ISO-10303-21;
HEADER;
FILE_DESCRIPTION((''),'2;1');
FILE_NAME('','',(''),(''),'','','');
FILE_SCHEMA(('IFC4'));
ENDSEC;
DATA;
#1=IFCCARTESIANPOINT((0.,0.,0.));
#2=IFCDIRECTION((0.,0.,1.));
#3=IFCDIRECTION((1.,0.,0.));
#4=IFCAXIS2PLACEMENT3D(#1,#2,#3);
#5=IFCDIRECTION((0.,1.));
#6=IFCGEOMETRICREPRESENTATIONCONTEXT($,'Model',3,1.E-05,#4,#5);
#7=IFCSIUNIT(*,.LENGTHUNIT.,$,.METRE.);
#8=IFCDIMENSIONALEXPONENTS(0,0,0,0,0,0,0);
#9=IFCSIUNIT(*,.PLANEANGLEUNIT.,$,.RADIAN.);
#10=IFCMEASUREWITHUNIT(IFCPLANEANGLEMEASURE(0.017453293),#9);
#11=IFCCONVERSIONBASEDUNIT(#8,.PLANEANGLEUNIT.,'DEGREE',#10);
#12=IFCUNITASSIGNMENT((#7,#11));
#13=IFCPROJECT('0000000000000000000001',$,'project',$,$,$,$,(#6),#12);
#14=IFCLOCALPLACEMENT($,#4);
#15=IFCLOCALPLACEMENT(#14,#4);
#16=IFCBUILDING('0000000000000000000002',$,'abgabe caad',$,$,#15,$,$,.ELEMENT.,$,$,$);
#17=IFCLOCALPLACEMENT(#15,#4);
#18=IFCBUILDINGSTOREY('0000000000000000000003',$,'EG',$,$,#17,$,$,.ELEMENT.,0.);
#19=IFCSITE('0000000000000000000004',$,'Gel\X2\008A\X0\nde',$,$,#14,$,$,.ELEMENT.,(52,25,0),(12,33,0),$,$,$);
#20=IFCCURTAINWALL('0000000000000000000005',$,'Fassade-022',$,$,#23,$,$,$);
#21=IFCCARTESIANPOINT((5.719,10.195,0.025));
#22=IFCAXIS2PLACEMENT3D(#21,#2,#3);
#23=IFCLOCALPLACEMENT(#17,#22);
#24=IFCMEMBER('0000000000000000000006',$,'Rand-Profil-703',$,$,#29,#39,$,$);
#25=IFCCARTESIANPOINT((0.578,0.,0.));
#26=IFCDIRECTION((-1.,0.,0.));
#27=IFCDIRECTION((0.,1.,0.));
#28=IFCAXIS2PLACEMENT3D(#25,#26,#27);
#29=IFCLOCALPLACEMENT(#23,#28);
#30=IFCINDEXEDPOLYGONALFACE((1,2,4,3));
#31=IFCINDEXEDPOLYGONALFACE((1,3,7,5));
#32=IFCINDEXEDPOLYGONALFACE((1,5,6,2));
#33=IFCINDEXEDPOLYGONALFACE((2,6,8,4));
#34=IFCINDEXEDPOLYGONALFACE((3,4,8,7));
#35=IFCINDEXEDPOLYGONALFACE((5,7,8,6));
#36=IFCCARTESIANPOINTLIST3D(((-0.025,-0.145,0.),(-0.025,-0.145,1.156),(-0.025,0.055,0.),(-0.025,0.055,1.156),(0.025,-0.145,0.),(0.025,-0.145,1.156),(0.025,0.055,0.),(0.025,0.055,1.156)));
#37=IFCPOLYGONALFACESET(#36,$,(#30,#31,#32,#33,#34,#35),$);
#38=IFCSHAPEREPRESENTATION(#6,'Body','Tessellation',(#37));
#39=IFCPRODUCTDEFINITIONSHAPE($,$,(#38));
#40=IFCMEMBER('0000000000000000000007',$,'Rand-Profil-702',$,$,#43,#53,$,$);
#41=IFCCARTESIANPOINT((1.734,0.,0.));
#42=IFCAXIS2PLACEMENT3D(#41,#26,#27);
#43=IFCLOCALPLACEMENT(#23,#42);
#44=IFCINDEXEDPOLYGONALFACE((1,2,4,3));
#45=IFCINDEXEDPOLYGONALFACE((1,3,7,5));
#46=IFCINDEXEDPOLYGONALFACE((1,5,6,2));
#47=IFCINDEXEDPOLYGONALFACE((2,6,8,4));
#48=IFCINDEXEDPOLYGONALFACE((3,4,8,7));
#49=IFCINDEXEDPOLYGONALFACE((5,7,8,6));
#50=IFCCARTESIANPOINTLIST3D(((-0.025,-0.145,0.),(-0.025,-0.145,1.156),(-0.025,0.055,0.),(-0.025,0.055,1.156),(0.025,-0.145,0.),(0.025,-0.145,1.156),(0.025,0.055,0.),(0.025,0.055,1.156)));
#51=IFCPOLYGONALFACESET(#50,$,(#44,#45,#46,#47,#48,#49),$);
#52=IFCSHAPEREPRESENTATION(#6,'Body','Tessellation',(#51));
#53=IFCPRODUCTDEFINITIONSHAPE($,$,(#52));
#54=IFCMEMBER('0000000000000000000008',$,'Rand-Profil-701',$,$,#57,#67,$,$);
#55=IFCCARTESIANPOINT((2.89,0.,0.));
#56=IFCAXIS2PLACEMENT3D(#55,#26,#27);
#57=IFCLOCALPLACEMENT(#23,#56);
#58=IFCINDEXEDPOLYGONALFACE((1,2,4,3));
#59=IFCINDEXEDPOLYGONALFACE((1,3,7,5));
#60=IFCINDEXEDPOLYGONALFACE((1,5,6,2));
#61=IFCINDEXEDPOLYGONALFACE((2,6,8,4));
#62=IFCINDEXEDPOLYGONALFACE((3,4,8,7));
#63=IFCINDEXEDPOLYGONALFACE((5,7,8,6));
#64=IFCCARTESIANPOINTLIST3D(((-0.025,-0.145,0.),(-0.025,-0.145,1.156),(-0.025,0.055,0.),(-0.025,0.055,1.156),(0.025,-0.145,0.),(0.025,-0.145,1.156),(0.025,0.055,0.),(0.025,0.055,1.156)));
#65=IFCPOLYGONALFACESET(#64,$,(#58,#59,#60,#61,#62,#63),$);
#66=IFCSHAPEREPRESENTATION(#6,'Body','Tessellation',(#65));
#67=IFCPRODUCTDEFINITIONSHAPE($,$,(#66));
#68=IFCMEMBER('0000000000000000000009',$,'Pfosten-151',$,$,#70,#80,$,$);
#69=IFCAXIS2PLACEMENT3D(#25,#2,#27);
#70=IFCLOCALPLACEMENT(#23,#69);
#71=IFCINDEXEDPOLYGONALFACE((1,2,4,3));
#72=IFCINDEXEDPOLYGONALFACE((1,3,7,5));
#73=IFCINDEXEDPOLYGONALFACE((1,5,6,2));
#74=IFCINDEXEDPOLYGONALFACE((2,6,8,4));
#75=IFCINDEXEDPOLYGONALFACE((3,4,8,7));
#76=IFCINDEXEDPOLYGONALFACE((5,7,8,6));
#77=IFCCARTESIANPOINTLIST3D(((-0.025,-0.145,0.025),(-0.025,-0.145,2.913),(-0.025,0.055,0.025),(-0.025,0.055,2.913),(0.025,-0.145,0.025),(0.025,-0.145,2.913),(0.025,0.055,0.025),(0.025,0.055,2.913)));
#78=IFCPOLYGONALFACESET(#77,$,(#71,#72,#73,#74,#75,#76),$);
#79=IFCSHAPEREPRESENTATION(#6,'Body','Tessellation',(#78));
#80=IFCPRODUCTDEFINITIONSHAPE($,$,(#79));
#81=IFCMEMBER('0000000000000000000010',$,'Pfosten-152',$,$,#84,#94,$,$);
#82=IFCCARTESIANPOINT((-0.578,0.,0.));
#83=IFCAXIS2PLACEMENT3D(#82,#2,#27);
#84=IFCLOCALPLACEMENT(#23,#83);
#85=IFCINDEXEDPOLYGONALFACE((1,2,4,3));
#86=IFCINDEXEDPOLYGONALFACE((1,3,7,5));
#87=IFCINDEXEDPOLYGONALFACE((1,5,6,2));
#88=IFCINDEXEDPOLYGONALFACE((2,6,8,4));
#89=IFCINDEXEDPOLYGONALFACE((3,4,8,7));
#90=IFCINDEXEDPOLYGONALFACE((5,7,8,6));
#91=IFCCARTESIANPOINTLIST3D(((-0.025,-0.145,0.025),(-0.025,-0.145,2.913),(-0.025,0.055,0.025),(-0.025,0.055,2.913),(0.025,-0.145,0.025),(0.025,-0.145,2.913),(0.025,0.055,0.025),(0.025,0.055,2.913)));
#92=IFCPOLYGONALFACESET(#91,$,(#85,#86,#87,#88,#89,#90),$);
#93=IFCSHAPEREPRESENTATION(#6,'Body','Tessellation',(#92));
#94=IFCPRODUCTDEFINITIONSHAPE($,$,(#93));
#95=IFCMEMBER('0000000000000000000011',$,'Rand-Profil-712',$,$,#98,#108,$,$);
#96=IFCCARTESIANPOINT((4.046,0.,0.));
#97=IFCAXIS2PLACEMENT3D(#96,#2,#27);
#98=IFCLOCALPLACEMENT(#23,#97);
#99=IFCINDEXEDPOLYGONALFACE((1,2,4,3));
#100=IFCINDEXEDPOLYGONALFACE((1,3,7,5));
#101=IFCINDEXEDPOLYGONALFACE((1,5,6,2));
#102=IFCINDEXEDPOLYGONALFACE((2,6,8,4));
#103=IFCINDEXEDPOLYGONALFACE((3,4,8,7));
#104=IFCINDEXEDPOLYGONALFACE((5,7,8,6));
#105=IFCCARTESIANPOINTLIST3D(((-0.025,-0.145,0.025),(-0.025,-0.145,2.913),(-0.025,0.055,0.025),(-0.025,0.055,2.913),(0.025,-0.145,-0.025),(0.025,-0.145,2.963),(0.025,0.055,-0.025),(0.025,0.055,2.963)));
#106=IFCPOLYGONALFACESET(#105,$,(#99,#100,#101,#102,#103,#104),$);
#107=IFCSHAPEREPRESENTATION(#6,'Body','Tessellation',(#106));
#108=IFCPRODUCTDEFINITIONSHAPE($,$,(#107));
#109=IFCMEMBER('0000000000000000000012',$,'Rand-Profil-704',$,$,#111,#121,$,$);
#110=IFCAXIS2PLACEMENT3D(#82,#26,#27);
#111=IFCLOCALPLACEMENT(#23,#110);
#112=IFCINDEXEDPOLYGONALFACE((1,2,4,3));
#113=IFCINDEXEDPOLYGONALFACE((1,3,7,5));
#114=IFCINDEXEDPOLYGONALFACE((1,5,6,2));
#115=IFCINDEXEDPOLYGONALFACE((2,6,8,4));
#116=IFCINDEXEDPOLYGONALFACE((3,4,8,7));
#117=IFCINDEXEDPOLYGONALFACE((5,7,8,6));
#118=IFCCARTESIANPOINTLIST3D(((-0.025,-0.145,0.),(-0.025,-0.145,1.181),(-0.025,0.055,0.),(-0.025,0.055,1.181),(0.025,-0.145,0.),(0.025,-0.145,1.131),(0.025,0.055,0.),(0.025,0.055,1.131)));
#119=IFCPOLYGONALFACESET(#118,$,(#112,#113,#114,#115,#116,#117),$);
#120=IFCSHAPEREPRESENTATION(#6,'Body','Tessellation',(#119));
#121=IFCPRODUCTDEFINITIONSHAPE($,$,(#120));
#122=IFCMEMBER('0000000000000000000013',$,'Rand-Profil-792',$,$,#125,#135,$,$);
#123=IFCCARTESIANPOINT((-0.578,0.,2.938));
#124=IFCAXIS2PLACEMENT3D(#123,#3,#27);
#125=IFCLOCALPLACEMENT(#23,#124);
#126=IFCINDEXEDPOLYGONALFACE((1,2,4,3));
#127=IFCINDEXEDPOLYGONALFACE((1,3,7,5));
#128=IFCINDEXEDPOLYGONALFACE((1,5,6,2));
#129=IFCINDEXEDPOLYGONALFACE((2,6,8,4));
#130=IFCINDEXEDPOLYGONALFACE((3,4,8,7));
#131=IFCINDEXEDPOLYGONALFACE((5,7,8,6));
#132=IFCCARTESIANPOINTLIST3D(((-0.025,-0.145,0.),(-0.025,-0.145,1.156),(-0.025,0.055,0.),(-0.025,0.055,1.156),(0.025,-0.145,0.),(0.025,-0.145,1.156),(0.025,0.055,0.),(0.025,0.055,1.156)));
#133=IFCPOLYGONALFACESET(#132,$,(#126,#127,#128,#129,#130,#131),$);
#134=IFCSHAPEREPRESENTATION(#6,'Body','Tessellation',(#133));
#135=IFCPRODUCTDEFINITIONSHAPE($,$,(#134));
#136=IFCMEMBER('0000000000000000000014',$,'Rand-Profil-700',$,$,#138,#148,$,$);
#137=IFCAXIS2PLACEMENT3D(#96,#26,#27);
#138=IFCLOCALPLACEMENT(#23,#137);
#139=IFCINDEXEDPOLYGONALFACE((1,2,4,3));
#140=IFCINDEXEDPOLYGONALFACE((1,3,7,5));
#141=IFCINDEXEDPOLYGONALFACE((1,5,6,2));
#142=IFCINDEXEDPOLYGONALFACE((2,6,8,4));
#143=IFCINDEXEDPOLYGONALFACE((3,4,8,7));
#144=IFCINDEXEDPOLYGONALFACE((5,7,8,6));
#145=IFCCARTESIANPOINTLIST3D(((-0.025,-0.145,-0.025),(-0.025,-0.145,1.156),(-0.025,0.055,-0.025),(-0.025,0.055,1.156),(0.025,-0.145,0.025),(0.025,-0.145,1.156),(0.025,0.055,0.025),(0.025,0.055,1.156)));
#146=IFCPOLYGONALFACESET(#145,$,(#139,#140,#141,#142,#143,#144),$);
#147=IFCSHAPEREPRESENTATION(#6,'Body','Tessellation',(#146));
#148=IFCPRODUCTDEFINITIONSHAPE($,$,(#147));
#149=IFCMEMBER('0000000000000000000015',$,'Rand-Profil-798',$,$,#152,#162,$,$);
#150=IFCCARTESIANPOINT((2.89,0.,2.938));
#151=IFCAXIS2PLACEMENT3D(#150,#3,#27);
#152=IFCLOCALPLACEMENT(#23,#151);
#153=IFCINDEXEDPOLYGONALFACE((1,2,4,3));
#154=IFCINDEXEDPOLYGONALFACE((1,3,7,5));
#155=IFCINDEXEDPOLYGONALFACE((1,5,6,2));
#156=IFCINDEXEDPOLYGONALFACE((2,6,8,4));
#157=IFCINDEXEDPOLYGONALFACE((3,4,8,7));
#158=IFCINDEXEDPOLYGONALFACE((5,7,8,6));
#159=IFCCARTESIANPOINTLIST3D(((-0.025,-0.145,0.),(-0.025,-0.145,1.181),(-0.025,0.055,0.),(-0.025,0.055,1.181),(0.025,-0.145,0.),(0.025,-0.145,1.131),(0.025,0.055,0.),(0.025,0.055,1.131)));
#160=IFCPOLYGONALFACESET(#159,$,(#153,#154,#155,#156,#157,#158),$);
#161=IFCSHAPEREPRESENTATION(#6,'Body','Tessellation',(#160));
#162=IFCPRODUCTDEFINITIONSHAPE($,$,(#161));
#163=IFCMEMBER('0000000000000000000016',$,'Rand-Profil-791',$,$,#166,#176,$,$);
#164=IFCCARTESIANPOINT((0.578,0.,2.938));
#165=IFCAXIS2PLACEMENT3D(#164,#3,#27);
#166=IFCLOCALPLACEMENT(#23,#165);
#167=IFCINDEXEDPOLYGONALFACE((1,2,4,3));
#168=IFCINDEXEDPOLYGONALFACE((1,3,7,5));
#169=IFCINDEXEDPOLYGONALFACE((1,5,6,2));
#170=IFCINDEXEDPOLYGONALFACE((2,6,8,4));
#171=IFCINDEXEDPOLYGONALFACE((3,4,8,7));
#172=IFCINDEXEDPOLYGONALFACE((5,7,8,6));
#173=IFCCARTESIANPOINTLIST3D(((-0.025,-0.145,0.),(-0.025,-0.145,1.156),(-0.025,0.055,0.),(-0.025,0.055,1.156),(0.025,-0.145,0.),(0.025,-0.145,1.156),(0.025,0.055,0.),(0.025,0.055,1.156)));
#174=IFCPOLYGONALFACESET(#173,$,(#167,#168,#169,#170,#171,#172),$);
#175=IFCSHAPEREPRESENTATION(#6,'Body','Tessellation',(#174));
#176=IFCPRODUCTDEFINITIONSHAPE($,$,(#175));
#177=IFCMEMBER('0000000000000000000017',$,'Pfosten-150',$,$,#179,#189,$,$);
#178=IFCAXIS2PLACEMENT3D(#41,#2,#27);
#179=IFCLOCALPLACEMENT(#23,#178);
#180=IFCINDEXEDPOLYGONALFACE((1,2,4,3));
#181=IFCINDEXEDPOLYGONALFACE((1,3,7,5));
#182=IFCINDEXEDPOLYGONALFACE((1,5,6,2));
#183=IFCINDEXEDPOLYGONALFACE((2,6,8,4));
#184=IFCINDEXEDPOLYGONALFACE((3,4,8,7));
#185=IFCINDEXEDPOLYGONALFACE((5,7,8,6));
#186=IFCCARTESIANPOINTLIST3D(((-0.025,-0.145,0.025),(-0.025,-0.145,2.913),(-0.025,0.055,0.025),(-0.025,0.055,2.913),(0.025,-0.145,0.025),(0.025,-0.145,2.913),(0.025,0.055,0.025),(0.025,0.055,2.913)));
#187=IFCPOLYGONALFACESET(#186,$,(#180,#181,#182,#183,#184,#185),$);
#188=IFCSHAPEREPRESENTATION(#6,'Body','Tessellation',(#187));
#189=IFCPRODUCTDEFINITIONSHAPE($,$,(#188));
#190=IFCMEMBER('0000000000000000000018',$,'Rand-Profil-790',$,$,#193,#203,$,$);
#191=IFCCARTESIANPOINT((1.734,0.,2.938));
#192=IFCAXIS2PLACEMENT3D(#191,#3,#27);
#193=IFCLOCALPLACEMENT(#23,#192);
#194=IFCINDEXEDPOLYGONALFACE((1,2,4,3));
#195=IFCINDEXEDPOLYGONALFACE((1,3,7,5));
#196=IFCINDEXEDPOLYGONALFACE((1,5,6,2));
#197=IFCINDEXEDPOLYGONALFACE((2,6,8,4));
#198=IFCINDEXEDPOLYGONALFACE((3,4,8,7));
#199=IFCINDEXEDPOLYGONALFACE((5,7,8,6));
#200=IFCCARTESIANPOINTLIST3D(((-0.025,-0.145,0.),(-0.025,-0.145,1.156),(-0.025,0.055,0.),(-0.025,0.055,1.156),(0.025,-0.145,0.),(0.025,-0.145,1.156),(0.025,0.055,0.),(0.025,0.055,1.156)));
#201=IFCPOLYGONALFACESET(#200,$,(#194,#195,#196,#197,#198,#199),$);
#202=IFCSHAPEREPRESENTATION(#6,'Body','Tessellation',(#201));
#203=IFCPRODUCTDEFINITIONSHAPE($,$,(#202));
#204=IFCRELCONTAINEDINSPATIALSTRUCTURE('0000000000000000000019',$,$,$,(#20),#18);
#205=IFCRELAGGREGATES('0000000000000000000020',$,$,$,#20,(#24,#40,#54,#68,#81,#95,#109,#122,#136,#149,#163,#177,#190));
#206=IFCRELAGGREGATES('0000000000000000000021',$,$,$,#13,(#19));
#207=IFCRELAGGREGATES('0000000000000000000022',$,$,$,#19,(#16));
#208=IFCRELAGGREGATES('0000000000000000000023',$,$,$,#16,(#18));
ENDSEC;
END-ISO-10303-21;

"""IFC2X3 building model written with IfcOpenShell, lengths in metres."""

from ifc_helpers import new_model, entity, si_unit, converted_unit, direction, frame, origin_with_axes, place, context, project, spatial, polyline, outline, extrude, clip, halfspace, element, aggregate, save


model = new_model("IFC2X3")

# Units and contexts
model_context = context("Model", 3, precision=1e-05, world=origin_with_axes(), true_north=direction((0.0, 1.0)))
ifc_project = project(units=[si_unit("LENGTHUNIT", "METRE"), converted_unit("PLANEANGLEUNIT", "DEGREE", entity("IfcPlaneAngleMeasure", 0.017453293), si_unit("PLANEANGLEUNIT", "RADIAN"), dimensions=[0, 0, 0, 0, 0, 0, 0])], contexts=[model_context])

# Site, building, storey
site_placement = place(None, origin_with_axes())
site = spatial("IfcSite", under=ifc_project, at=site_placement, Name="Gel\u008ande", CompositionType="ELEMENT", RefLatitude=(52, 25, 0), RefLongitude=(12, 33, 0))
building_placement = place(site_placement, origin_with_axes())
building = spatial("IfcBuilding", under=site, at=building_placement, Name="abgabe caad", CompositionType="ELEMENT")
storey_placement = place(building_placement, origin_with_axes())
storey = spatial("IfcBuildingStorey", under=building, at=storey_placement, Name="EG", CompositionType="ELEMENT", Elevation=0.0)

# Curtain wall, members
curtain_wall_placement = place(storey_placement, frame((5.719, 10.195, 0.025), z_axis=(0.0, 0.0, 1.0), x_axis=(1.0, 0.0, 0.0)))
curtain_wall = element("IfcCurtainWall", 1, at=curtain_wall_placement, inside=storey, Name="Fassade-022")
member_1_placement = place(curtain_wall_placement, frame((0.578, 0.0, 0.0), z_axis=(-1.0, 0.0, 0.0), x_axis=(0.0, 1.0, 0.0)))
member_1 = element("IfcMember", 2, at=member_1_placement, Name="Rand-Profil-703", context=model_context, shape_type="SweptSolid", body=[
    extrude(outline(polyline([(0.025, -0.145), (0.025, 0.055), (-0.025, 0.055), (-0.025, -0.145), (0.025, -0.145)])), origin_with_axes(), (0.0, 0.0, 1.0), 1.156),
])
member_2_placement = place(curtain_wall_placement, frame((1.734, 0.0, 0.0), z_axis=(-1.0, 0.0, 0.0), x_axis=(0.0, 1.0, 0.0)))
member_2 = element("IfcMember", 3, at=member_2_placement, Name="Rand-Profil-702", context=model_context, shape_type="SweptSolid", body=[
    extrude(outline(polyline([(0.025, -0.145), (0.025, 0.055), (-0.025, 0.055), (-0.025, -0.145), (0.025, -0.145)])), origin_with_axes(), (0.0, 0.0, 1.0), 1.156),
])
member_3_placement = place(curtain_wall_placement, frame((2.89, 0.0, 0.0), z_axis=(-1.0, 0.0, 0.0), x_axis=(0.0, 1.0, 0.0)))
member_3 = element("IfcMember", 4, at=member_3_placement, Name="Rand-Profil-701", context=model_context, shape_type="SweptSolid", body=[
    extrude(outline(polyline([(0.025, -0.145), (0.025, 0.055), (-0.025, 0.055), (-0.025, -0.145), (0.025, -0.145)])), origin_with_axes(), (0.0, 0.0, 1.0), 1.156),
])
member_4_placement = place(curtain_wall_placement, frame((0.578, 0.0, 0.0), z_axis=(0.0, 0.0, 1.0), x_axis=(0.0, 1.0, 0.0)))
member_4 = element("IfcMember", 5, at=member_4_placement, Name="Pfosten-151", context=model_context, shape_type="SweptSolid", body=[
    extrude(outline(polyline([(0.145, 0.025), (-0.055, 0.025), (-0.055, -0.025), (0.145, -0.025), (0.145, 0.025)])), frame((0.0, 0.0, 0.025), z_axis=(0.0, 0.0, 1.0), x_axis=(0.0, -1.0, 0.0)), (0.0, 0.0, 1.0), 2.888),
])
member_5_placement = place(curtain_wall_placement, frame((-0.578, 0.0, 0.0), z_axis=(0.0, 0.0, 1.0), x_axis=(0.0, 1.0, 0.0)))
member_5 = element("IfcMember", 6, at=member_5_placement, Name="Pfosten-152", context=model_context, shape_type="SweptSolid", body=[
    extrude(outline(polyline([(0.145, 0.025), (-0.055, 0.025), (-0.055, -0.025), (0.145, -0.025), (0.145, 0.025)])), frame((0.0, 0.0, 0.025), z_axis=(0.0, 0.0, 1.0), x_axis=(0.0, -1.0, 0.0)), (0.0, 0.0, 1.0), 2.888),
])
member_6_placement = place(curtain_wall_placement, frame((4.046, 0.0, 0.0), z_axis=(0.0, 0.0, 1.0), x_axis=(0.0, 1.0, 0.0)))
member_6 = element("IfcMember", 7, at=member_6_placement, Name="Rand-Profil-712", context=model_context, shape_type="Clipping", body=[
    clip(clip(extrude(outline(polyline([(0.145, 0.025), (-0.055, 0.025), (-0.055, -0.025), (0.145, -0.025), (0.145, 0.025)])), frame((0.0, 0.0, -0.025), z_axis=(0.0, 0.0, 1.0), x_axis=(0.0, -1.0, 0.0)), (0.0, 0.0, 1.0), 2.988), halfspace(frame((0.0, 0.0, 0.0), z_axis=(0.707107, 0.0, 0.707107), x_axis=(-0.707107, 0.0, 0.707107)), True)), halfspace(frame((-1.469, 0.0, 1.469), z_axis=(0.707107, 0.0, -0.707107), x_axis=(0.707107, 0.0, 0.707107)), True)),
])
member_7_placement = place(curtain_wall_placement, frame((-0.578, 0.0, 0.0), z_axis=(-1.0, 0.0, 0.0), x_axis=(0.0, 1.0, 0.0)))
member_7 = element("IfcMember", 8, at=member_7_placement, Name="Rand-Profil-704", context=model_context, shape_type="Clipping", body=[
    clip(extrude(outline(polyline([(0.025, -0.145), (0.025, 0.055), (-0.025, 0.055), (-0.025, -0.145), (0.025, -0.145)])), origin_with_axes(), (0.0, 0.0, 1.0), 1.181), halfspace(frame((0.578, 0.0, 0.578), z_axis=(-0.707107, 0.0, -0.707107), x_axis=(0.707107, 0.0, -0.707107)), True)),
])
member_8_placement = place(curtain_wall_placement, frame((-0.578, 0.0, 2.938), z_axis=(1.0, 0.0, 0.0), x_axis=(0.0, 1.0, 0.0)))
member_8 = element("IfcMember", 9, at=member_8_placement, Name="Rand-Profil-792", context=model_context, shape_type="SweptSolid", body=[
    extrude(outline(polyline([(-0.025, 0.145), (-0.025, -0.055), (0.025, -0.055), (0.025, 0.145), (-0.025, 0.145)])), frame((0.0, 0.0, 0.0), z_axis=(0.0, 0.0, 1.0), x_axis=(-1.0, 0.0, 0.0)), (0.0, 0.0, 1.0), 1.156),
])
member_9_placement = place(curtain_wall_placement, frame((4.046, 0.0, 0.0), z_axis=(-1.0, 0.0, 0.0), x_axis=(0.0, 1.0, 0.0)))
member_9 = element("IfcMember", 10, at=member_9_placement, Name="Rand-Profil-700", context=model_context, shape_type="Clipping", body=[
    clip(extrude(outline(polyline([(0.025, -0.145), (0.025, 0.055), (-0.025, 0.055), (-0.025, -0.145), (0.025, -0.145)])), frame((0.0, 0.0, -0.025), z_axis=(0.0, 0.0, 1.0), x_axis=(1.0, 0.0, 0.0)), (0.0, 0.0, 1.0), 1.181), halfspace(frame((0.0, 0.0, 0.0), z_axis=(-0.707107, 0.0, 0.707107), x_axis=(-0.707107, 0.0, -0.707107)), True)),
])
member_10_placement = place(curtain_wall_placement, frame((2.89, 0.0, 2.938), z_axis=(1.0, 0.0, 0.0), x_axis=(0.0, 1.0, 0.0)))
member_10 = element("IfcMember", 11, at=member_10_placement, Name="Rand-Profil-798", context=model_context, shape_type="Clipping", body=[
    clip(extrude(outline(polyline([(-0.025, 0.145), (-0.025, -0.055), (0.025, -0.055), (0.025, 0.145), (-0.025, 0.145)])), frame((0.0, 0.0, 0.0), z_axis=(0.0, 0.0, 1.0), x_axis=(-1.0, 0.0, 0.0)), (0.0, 0.0, 1.0), 1.181), halfspace(frame((0.578, 0.0, 0.578), z_axis=(-0.707107, 0.0, -0.707107), x_axis=(0.707107, 0.0, -0.707107)), True)),
])
member_11_placement = place(curtain_wall_placement, frame((0.578, 0.0, 2.938), z_axis=(1.0, 0.0, 0.0), x_axis=(0.0, 1.0, 0.0)))
member_11 = element("IfcMember", 12, at=member_11_placement, Name="Rand-Profil-791", context=model_context, shape_type="SweptSolid", body=[
    extrude(outline(polyline([(-0.025, 0.145), (-0.025, -0.055), (0.025, -0.055), (0.025, 0.145), (-0.025, 0.145)])), frame((0.0, 0.0, 0.0), z_axis=(0.0, 0.0, 1.0), x_axis=(-1.0, 0.0, 0.0)), (0.0, 0.0, 1.0), 1.156),
])
member_12_placement = place(curtain_wall_placement, frame((1.734, 0.0, 0.0), z_axis=(0.0, 0.0, 1.0), x_axis=(0.0, 1.0, 0.0)))
member_12 = element("IfcMember", 13, at=member_12_placement, Name="Pfosten-150", context=model_context, shape_type="SweptSolid", body=[
    extrude(outline(polyline([(0.145, 0.025), (-0.055, 0.025), (-0.055, -0.025), (0.145, -0.025), (0.145, 0.025)])), frame((0.0, 0.0, 0.025), z_axis=(0.0, 0.0, 1.0), x_axis=(0.0, -1.0, 0.0)), (0.0, 0.0, 1.0), 2.888),
])
member_13_placement = place(curtain_wall_placement, frame((1.734, 0.0, 2.938), z_axis=(1.0, 0.0, 0.0), x_axis=(0.0, 1.0, 0.0)))
member_13 = element("IfcMember", 14, at=member_13_placement, Name="Rand-Profil-790", context=model_context, shape_type="SweptSolid", body=[
    extrude(outline(polyline([(-0.025, 0.145), (-0.025, -0.055), (0.025, -0.055), (0.025, 0.145), (-0.025, 0.145)])), frame((0.0, 0.0, 0.0), z_axis=(0.0, 0.0, 1.0), x_axis=(-1.0, 0.0, 0.0)), (0.0, 0.0, 1.0), 1.156),
])
aggregate(curtain_wall, [member_1, member_2, member_3, member_4, member_5, member_6, member_7, member_8, member_9, member_10, member_11, member_12, member_13])

save(model, "model.ifc")
